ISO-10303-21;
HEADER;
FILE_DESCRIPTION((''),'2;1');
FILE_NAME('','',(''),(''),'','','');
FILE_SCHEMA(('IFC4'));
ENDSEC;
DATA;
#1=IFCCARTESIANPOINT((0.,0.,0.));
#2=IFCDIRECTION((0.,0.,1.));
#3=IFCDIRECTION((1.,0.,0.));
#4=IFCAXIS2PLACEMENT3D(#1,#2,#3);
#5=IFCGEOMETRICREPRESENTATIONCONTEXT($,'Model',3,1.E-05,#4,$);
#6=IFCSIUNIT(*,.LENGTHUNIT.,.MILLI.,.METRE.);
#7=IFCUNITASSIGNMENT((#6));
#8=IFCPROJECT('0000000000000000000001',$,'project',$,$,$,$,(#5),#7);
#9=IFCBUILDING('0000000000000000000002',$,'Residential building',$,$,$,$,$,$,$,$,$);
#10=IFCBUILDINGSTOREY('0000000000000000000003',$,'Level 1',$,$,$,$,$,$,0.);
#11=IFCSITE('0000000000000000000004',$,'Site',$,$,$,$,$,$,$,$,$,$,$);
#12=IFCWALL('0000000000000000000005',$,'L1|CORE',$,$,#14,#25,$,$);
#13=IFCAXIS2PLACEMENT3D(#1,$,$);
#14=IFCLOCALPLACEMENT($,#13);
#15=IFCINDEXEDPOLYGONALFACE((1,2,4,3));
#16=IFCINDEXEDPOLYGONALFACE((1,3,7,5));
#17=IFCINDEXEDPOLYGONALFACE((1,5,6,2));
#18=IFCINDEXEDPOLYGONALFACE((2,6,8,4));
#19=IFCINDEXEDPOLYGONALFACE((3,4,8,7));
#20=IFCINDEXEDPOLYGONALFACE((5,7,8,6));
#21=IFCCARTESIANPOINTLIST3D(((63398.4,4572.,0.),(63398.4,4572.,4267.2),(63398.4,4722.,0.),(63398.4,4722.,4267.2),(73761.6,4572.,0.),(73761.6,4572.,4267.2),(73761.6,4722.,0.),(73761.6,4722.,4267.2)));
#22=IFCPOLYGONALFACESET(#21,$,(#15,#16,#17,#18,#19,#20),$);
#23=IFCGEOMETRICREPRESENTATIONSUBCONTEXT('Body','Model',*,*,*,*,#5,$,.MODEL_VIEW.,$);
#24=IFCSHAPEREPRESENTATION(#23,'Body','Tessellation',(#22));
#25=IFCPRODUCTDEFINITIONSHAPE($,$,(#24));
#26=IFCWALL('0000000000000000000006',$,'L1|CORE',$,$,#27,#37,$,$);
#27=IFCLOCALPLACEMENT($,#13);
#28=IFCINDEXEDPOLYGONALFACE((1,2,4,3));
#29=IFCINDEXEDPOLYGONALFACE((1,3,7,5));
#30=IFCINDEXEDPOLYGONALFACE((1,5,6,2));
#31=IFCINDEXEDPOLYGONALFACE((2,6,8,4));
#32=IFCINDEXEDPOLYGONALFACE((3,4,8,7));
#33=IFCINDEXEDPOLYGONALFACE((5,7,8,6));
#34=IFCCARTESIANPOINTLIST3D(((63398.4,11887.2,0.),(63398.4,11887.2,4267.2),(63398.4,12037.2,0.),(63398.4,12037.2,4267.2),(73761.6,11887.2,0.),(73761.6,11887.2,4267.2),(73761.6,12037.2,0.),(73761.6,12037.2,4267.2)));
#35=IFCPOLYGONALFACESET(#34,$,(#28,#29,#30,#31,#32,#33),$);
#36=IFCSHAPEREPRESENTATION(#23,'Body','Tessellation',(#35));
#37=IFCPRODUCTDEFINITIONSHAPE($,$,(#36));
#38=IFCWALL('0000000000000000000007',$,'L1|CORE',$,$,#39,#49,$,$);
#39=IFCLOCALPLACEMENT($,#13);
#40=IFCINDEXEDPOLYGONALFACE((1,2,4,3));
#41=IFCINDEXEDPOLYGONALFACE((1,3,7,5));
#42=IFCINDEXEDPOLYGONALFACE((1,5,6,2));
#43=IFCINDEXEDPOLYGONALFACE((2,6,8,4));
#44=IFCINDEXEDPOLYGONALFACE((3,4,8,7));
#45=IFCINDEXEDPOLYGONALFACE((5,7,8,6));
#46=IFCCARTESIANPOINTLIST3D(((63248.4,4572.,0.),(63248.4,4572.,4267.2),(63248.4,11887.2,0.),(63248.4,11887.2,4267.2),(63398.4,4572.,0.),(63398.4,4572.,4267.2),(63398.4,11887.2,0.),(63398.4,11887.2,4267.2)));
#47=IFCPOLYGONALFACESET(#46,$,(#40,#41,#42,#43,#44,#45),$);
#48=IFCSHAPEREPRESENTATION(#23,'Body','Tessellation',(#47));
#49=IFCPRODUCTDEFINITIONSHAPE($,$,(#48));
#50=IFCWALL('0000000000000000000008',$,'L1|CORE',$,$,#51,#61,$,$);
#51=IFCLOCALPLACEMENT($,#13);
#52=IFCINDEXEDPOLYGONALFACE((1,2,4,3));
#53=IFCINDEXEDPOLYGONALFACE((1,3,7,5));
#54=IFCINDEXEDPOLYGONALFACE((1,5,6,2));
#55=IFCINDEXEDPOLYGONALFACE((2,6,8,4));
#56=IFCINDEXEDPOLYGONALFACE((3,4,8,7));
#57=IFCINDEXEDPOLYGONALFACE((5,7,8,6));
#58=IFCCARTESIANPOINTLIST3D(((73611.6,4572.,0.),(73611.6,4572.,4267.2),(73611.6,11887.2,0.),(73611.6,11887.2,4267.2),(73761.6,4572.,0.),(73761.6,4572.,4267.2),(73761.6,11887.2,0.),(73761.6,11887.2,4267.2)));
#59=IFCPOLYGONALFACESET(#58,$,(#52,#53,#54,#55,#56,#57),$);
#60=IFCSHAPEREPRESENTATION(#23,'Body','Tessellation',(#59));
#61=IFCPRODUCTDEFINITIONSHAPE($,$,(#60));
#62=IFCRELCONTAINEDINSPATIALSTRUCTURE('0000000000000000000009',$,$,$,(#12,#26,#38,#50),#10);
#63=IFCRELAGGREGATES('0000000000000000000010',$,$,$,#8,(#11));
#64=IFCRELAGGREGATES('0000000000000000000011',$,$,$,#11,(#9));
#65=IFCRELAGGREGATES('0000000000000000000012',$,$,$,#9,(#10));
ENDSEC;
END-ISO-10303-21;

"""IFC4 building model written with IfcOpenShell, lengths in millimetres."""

from ifc_helpers import new_model, si_unit, frame, origin_with_axes, place, context, subcontext, project, spatial, indexed_curve, outline, extrude, element, save


model = new_model("IFC4")

# Units and contexts
model_context = context("Model", 3, precision=1e-05, world=origin_with_axes())
body_context = subcontext(model_context, "Body", "Model", "MODEL_VIEW")
ifc_project = project(units=[si_unit("LENGTHUNIT", "METRE", prefix="MILLI")], contexts=[model_context])

# Site, building, storey
site = spatial("IfcSite", under=ifc_project, Name="Site")
building = spatial("IfcBuilding", under=site, Name="Residential building")
storey = spatial("IfcBuildingStorey", under=building, Name="Level 1", Elevation=0.0)

# Walls
for number, where, z_axis, x_axis, name in (
    (1, (63398.4, 4572.0, 0.0), (0.0, 0.0, 1.0), (1.0, 0.0, 0.0), "L1|CORE"),
    (2, (63398.4, 11887.2, 0.0), (0.0, 0.0, 1.0), (1.0, 0.0, 0.0), "L1|CORE"),
):
    element("IfcWall", number, at=place(None, frame(where, z_axis=z_axis, x_axis=x_axis)), inside=storey, Name=name, context=body_context, shape_type="SweptSolid", body=[
        extrude(outline(indexed_curve([(0.0, 0.0), (0.0, 150.0), (10363.2, 150.0), (10363.2, 0.0), (0.0, 0.0)], self_intersect=False)), origin_with_axes(), (0.0, 0.0, 1.0), 4267.2),
    ])
for number, where, z_axis, x_axis, name in (
    (3, (63398.4, 4572.0, 0.0), (0.0, 0.0, 1.0), (0.0, 1.0, 0.0), "L1|CORE"),
    (4, (73761.6, 4572.0, 0.0), (0.0, 0.0, 1.0), (0.0, 1.0, 0.0), "L1|CORE"),
):
    element("IfcWall", number, at=place(None, frame(where, z_axis=z_axis, x_axis=x_axis)), inside=storey, Name=name, context=body_context, shape_type="SweptSolid", body=[
        extrude(outline(indexed_curve([(0.0, 0.0), (0.0, 150.0), (7315.2, 150.0), (7315.2, 0.0), (0.0, 0.0)], self_intersect=False)), origin_with_axes(), (0.0, 0.0, 1.0), 4267.2),
    ])

save(model, "model.ifc")
